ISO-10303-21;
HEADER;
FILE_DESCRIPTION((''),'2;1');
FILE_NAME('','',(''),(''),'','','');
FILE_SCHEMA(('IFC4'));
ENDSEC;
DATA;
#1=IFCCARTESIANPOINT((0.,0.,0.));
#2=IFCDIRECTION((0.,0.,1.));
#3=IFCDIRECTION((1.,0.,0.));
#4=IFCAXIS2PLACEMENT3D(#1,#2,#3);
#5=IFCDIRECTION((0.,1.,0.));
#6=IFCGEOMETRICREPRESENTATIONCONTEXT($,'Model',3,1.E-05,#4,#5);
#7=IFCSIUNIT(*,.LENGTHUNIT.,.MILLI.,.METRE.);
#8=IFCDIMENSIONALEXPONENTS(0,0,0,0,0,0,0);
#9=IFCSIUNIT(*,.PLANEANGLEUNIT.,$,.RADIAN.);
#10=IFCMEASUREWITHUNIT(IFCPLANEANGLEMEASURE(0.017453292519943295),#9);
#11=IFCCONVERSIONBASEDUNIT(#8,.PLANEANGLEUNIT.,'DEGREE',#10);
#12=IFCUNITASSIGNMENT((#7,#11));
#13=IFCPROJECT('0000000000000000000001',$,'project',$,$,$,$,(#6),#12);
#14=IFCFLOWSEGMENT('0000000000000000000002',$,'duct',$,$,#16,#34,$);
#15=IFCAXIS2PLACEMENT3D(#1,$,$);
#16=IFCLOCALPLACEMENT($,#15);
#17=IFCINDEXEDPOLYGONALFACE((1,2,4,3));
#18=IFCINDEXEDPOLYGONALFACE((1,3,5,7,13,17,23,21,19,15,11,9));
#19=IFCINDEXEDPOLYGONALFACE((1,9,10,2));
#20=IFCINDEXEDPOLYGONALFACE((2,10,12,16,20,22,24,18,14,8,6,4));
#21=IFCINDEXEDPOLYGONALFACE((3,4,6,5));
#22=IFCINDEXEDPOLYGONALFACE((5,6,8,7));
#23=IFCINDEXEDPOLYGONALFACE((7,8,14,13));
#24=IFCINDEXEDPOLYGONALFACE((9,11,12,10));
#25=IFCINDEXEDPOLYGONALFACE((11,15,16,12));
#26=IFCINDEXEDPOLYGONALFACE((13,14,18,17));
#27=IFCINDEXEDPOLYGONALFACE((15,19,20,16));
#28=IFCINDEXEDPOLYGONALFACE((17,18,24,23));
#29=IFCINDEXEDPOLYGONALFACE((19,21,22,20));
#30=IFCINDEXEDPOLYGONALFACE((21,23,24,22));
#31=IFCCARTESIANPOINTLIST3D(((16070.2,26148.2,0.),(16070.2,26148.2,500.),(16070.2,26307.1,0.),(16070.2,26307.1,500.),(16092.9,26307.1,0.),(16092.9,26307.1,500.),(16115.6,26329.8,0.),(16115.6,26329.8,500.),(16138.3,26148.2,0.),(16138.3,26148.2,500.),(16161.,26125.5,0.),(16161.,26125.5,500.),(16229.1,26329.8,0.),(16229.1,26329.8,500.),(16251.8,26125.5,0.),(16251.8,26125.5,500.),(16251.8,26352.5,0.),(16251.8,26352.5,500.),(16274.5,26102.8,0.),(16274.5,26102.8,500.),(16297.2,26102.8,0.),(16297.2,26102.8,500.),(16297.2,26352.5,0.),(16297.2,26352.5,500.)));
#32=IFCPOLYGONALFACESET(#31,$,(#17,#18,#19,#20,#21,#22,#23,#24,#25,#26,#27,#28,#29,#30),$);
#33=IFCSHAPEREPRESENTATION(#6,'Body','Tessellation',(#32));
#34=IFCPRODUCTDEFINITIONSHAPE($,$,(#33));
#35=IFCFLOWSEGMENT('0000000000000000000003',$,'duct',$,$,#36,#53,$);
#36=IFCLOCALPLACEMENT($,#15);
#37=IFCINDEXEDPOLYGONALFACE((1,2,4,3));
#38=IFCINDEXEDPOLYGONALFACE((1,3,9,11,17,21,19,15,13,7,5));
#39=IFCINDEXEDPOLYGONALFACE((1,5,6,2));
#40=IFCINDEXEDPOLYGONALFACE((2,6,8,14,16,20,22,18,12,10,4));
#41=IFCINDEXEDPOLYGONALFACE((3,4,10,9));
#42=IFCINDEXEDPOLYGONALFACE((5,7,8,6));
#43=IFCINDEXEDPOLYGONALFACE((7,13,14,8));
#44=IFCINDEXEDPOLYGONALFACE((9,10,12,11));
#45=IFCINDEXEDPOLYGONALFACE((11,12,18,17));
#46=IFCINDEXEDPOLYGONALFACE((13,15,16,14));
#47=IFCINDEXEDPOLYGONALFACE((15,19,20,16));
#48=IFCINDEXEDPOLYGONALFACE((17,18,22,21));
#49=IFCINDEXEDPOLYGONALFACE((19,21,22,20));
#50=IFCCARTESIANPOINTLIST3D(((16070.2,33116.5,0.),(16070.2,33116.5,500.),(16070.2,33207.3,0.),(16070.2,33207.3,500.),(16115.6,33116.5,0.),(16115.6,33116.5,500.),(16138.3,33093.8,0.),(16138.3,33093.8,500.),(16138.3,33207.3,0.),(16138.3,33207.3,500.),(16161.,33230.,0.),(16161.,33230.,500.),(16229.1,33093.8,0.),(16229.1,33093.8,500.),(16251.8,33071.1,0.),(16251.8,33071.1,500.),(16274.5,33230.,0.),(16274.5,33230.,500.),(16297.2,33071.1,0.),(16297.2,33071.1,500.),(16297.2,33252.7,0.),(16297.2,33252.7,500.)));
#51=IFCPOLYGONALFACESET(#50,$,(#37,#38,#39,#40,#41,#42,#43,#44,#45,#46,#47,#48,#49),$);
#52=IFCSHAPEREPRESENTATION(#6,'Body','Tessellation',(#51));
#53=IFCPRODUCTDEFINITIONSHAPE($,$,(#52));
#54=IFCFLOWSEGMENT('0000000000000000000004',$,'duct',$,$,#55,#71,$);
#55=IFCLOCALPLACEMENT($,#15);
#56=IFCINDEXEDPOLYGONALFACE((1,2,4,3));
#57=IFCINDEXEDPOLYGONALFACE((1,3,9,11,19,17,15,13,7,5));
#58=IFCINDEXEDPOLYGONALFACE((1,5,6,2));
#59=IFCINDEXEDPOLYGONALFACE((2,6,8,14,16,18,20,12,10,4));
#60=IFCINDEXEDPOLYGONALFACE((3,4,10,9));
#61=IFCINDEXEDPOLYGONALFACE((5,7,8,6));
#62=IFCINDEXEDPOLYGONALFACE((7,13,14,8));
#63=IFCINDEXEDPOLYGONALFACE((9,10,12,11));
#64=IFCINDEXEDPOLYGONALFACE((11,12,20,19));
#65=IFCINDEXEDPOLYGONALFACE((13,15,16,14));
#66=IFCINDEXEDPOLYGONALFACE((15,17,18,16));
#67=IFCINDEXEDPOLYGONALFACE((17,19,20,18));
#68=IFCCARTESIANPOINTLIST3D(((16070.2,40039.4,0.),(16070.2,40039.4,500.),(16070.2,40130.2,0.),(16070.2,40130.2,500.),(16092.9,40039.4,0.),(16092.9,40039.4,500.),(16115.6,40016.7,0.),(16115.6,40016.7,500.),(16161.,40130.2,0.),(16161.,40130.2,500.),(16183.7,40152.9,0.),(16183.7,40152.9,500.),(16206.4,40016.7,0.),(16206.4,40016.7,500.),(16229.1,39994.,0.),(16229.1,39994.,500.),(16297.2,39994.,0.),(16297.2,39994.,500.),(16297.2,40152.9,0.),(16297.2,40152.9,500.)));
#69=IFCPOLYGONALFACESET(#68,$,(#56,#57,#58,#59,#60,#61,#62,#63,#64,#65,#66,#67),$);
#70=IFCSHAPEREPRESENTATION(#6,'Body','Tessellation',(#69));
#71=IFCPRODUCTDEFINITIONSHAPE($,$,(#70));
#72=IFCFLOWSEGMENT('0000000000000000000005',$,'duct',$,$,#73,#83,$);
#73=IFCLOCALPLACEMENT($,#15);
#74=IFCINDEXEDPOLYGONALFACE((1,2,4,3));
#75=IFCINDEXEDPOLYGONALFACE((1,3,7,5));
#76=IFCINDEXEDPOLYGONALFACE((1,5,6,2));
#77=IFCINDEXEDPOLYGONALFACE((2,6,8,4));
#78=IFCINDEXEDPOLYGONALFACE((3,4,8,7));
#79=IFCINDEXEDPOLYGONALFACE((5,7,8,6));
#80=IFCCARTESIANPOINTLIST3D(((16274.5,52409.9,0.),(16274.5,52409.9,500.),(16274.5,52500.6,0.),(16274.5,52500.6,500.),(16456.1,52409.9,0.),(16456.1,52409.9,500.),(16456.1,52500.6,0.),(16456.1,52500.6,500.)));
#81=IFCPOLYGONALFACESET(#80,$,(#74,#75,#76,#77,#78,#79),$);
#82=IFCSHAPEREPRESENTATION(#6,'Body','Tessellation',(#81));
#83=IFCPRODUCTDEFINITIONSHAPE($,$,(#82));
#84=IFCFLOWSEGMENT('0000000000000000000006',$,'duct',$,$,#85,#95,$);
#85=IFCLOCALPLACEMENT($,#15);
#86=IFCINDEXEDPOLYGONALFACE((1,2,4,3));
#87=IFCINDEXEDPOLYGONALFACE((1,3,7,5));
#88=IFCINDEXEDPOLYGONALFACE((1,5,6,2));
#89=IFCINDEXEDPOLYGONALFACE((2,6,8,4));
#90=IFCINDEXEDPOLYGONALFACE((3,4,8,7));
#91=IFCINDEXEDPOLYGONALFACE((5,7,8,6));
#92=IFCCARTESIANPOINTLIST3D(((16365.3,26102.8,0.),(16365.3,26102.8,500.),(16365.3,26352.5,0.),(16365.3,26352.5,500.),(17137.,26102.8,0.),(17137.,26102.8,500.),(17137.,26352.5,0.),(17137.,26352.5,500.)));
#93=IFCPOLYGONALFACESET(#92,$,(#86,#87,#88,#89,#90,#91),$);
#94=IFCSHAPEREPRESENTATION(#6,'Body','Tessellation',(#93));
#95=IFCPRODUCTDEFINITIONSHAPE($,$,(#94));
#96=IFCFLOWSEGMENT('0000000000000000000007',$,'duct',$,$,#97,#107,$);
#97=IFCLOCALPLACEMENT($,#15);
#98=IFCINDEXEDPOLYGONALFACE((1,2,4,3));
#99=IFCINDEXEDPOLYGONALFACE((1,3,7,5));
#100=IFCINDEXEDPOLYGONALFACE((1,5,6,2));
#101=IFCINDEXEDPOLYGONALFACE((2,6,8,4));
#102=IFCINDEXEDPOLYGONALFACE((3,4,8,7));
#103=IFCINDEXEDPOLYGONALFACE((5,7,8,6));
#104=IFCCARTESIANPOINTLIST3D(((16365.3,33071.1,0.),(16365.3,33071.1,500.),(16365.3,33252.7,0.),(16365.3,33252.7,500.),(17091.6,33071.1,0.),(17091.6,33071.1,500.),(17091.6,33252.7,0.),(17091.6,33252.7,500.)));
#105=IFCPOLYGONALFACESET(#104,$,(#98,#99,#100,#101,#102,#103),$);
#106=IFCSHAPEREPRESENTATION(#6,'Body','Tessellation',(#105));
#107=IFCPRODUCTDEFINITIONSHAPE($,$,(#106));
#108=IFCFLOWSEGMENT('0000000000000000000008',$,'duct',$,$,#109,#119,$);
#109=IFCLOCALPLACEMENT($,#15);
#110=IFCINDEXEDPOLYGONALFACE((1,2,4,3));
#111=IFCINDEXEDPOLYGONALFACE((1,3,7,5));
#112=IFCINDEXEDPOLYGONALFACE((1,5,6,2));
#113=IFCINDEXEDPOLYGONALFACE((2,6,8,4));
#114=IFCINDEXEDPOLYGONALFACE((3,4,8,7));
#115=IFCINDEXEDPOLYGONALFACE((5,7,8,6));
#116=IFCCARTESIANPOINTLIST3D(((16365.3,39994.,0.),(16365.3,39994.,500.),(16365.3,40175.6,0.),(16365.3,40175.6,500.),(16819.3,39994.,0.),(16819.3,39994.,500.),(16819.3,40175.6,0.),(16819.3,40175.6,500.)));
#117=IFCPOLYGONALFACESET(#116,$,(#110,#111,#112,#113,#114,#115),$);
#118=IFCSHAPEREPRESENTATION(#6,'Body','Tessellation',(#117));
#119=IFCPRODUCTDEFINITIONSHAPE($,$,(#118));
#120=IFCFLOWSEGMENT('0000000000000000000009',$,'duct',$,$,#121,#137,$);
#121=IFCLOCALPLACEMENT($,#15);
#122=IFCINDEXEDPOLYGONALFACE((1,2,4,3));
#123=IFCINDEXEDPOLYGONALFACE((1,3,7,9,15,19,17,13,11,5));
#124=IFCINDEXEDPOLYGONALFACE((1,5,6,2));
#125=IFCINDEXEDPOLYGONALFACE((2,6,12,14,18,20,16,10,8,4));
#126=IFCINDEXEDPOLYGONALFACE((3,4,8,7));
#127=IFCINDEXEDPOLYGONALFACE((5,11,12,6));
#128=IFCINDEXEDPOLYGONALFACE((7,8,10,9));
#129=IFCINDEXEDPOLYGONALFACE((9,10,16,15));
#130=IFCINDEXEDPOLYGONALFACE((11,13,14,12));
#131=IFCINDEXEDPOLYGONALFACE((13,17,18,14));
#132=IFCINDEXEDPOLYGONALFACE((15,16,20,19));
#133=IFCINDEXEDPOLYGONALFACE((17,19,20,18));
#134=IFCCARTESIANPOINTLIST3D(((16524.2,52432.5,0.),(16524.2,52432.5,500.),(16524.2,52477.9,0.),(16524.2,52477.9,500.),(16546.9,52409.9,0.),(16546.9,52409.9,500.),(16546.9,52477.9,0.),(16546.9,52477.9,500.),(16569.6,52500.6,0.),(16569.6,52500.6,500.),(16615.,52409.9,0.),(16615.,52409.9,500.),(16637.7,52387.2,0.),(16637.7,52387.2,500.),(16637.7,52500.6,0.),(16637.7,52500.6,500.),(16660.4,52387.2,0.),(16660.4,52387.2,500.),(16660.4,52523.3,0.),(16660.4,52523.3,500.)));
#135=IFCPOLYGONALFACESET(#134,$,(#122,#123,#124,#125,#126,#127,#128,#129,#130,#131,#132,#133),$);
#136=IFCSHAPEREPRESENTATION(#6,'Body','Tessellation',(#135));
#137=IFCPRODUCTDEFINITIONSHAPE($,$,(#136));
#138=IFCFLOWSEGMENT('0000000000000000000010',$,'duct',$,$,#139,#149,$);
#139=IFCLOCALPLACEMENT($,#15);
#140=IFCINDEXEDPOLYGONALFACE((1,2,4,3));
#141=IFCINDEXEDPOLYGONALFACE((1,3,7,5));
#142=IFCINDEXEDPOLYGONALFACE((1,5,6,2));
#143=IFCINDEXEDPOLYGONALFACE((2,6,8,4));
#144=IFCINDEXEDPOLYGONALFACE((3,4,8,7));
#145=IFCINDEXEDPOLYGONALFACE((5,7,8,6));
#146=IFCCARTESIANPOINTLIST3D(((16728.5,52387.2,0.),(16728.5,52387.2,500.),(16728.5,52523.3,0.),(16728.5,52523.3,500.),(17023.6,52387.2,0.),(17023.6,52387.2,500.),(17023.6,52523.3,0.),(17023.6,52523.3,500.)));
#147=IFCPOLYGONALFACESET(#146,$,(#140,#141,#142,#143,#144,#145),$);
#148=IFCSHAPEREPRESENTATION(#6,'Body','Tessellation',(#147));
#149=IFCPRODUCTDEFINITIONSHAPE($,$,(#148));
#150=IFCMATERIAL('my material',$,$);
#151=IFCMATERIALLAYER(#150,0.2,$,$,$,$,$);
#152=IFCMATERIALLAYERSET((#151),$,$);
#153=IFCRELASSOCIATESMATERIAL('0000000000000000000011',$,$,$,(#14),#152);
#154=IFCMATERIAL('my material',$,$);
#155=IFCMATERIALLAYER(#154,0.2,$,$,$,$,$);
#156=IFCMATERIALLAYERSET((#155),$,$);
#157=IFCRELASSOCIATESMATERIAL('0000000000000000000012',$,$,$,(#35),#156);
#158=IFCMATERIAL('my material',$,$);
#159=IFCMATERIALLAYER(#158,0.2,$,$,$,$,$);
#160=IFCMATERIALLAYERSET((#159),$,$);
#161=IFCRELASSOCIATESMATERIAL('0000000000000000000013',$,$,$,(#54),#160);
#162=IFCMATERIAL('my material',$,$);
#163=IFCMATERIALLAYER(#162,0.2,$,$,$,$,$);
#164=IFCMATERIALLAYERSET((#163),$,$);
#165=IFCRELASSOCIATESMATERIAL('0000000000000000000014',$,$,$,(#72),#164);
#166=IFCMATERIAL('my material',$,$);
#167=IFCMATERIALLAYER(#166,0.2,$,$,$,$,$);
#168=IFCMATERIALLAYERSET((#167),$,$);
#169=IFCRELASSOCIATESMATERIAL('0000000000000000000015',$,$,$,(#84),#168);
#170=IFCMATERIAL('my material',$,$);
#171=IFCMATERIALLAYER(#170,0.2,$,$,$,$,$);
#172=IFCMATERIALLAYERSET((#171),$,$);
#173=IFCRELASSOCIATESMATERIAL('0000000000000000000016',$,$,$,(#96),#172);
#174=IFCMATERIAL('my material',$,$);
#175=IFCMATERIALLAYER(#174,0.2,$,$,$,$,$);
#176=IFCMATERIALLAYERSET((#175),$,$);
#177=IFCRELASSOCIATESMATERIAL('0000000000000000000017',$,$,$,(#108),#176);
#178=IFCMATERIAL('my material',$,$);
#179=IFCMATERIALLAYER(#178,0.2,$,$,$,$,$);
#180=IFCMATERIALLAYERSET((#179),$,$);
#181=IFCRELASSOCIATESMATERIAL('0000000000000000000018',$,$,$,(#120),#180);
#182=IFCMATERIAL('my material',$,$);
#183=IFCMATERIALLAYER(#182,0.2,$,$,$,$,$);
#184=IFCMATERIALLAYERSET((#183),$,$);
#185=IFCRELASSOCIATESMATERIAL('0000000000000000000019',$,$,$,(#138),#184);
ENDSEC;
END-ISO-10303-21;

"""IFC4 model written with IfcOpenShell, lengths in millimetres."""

from ifc_helpers import new_model, entity, si_unit, converted_unit, direction, origin_with_axes, place, context, project, polyline, outline, extrude, material, layer, layer_set, layer_usage, element, save


model = new_model("IFC4")

# Units and contexts
model_context = context("Model", 3, precision=1e-05, world=origin_with_axes(), true_north=direction((0.0, 1.0, 0.0)))
ifc_project = project(units=[si_unit("LENGTHUNIT", "METRE", prefix="MILLI"), converted_unit("PLANEANGLEUNIT", "DEGREE", entity("IfcPlaneAngleMeasure", 0.017453292519943295), si_unit("PLANEANGLEUNIT", "RADIAN"), dimensions=[0, 0, 0, 0, 0, 0, 0])], contexts=[model_context])

# Flow segments
ifc_material_1 = material(Name="my material")
ifc_layer_1 = layer(ifc_material_1, 0.2)
ifc_layer_set_1 = layer_set([ifc_layer_1])
ifc_layer_usage_1 = layer_usage(ifc_layer_set_1, "AXIS2", "POSITIVE", -0.1)
flow_segment_1_placement = place(None, origin_with_axes())
element("IfcFlowSegment", 1, at=flow_segment_1_placement, material=ifc_layer_usage_1, Name="duct", context=model_context, shape_type="SweptSolid", body=[
    extrude(outline(polyline([(16070.2, 26148.2), (16138.3, 26148.2), (16161.0, 26125.5), (16251.8, 26125.5), (16274.5, 26102.8), (16297.2, 26102.8), (16297.2, 26352.5), (16251.8, 26352.5), (16229.1, 26329.8), (16115.6, 26329.8), (16092.9, 26307.1), (16070.2, 26307.1), (16070.2, 26148.2)])), origin_with_axes(), (0.0, 0.0, 1.0), 500.0),
])
ifc_material_2 = material(Name="my material")
ifc_layer_2 = layer(ifc_material_2, 0.2)
ifc_layer_set_2 = layer_set([ifc_layer_2])
ifc_layer_usage_2 = layer_usage(ifc_layer_set_2, "AXIS2", "POSITIVE", -0.1)
flow_segment_2_placement = place(None, origin_with_axes())
element("IfcFlowSegment", 2, at=flow_segment_2_placement, material=ifc_layer_usage_2, Name="duct", context=model_context, shape_type="SweptSolid", body=[
    extrude(outline(polyline([(16070.2, 33116.5), (16115.6, 33116.5), (16138.3, 33093.8), (16229.1, 33093.8), (16251.8, 33071.1), (16297.2, 33071.1), (16297.2, 33252.7), (16274.5, 33230.0), (16161.0, 33230.0), (16138.3, 33207.3), (16070.2, 33207.3), (16070.2, 33116.5)])), origin_with_axes(), (0.0, 0.0, 1.0), 500.0),
])
ifc_material_3 = material(Name="my material")
ifc_layer_3 = layer(ifc_material_3, 0.2)
ifc_layer_set_3 = layer_set([ifc_layer_3])
ifc_layer_usage_3 = layer_usage(ifc_layer_set_3, "AXIS2", "POSITIVE", -0.1)
flow_segment_3_placement = place(None, origin_with_axes())
element("IfcFlowSegment", 3, at=flow_segment_3_placement, material=ifc_layer_usage_3, Name="duct", context=model_context, shape_type="SweptSolid", body=[
    extrude(outline(polyline([(16070.2, 40039.4), (16092.9, 40039.4), (16115.6, 40016.7), (16206.4, 40016.7), (16229.1, 39994.0), (16297.2, 39994.0), (16297.2, 40152.9), (16183.7, 40152.9), (16161.0, 40130.2), (16070.2, 40130.2), (16070.2, 40039.4)])), origin_with_axes(), (0.0, 0.0, 1.0), 500.0),
])
ifc_material_4 = material(Name="my material")
ifc_layer_4 = layer(ifc_material_4, 0.2)
ifc_layer_set_4 = layer_set([ifc_layer_4])
ifc_layer_usage_4 = layer_usage(ifc_layer_set_4, "AXIS2", "POSITIVE", -0.1)
flow_segment_4_placement = place(None, origin_with_axes())
element("IfcFlowSegment", 4, at=flow_segment_4_placement, material=ifc_layer_usage_4, Name="duct", context=model_context, shape_type="SweptSolid", body=[
    extrude(outline(polyline([(16274.5, 52409.9), (16456.1, 52409.9), (16456.1, 52500.6), (16274.5, 52500.6), (16274.5, 52409.9)])), origin_with_axes(), (0.0, 0.0, 1.0), 500.0),
])
ifc_material_5 = material(Name="my material")
ifc_layer_5 = layer(ifc_material_5, 0.2)
ifc_layer_set_5 = layer_set([ifc_layer_5])
ifc_layer_usage_5 = layer_usage(ifc_layer_set_5, "AXIS2", "POSITIVE", -0.1)
flow_segment_5_placement = place(None, origin_with_axes())
element("IfcFlowSegment", 5, at=flow_segment_5_placement, material=ifc_layer_usage_5, Name="duct", context=model_context, shape_type="SweptSolid", body=[
    extrude(outline(polyline([(16365.3, 26102.8), (17137.0, 26102.8), (17137.0, 26352.5), (16365.3, 26352.5), (16365.3, 26102.8)])), origin_with_axes(), (0.0, 0.0, 1.0), 500.0),
])
ifc_material_6 = material(Name="my material")
ifc_layer_6 = layer(ifc_material_6, 0.2)
ifc_layer_set_6 = layer_set([ifc_layer_6])
ifc_layer_usage_6 = layer_usage(ifc_layer_set_6, "AXIS2", "POSITIVE", -0.1)
flow_segment_6_placement = place(None, origin_with_axes())
element("IfcFlowSegment", 6, at=flow_segment_6_placement, material=ifc_layer_usage_6, Name="duct", context=model_context, shape_type="SweptSolid", body=[
    extrude(outline(polyline([(16365.3, 33071.1), (17091.6, 33071.1), (17091.6, 33252.7), (16365.3, 33252.7), (16365.3, 33071.1)])), origin_with_axes(), (0.0, 0.0, 1.0), 500.0),
])
ifc_material_7 = material(Name="my material")
ifc_layer_7 = layer(ifc_material_7, 0.2)
ifc_layer_set_7 = layer_set([ifc_layer_7])
ifc_layer_usage_7 = layer_usage(ifc_layer_set_7, "AXIS2", "POSITIVE", -0.1)
flow_segment_7_placement = place(None, origin_with_axes())
element("IfcFlowSegment", 7, at=flow_segment_7_placement, material=ifc_layer_usage_7, Name="duct", context=model_context, shape_type="SweptSolid", body=[
    extrude(outline(polyline([(16365.3, 39994.0), (16819.3, 39994.0), (16819.3, 40175.6), (16365.3, 40175.6), (16365.3, 39994.0)])), origin_with_axes(), (0.0, 0.0, 1.0), 500.0),
])
ifc_material_8 = material(Name="my material")
ifc_layer_8 = layer(ifc_material_8, 0.2)
ifc_layer_set_8 = layer_set([ifc_layer_8])
ifc_layer_usage_8 = layer_usage(ifc_layer_set_8, "AXIS2", "POSITIVE", -0.1)
flow_segment_8_placement = place(None, origin_with_axes())
element("IfcFlowSegment", 8, at=flow_segment_8_placement, material=ifc_layer_usage_8, Name="duct", context=model_context, shape_type="SweptSolid", body=[
    extrude(outline(polyline([(16524.2, 52432.5), (16546.9, 52409.9), (16615.0, 52409.9), (16637.7, 52387.2), (16660.4, 52387.2), (16660.4, 52523.3), (16637.7, 52500.6), (16569.6, 52500.6), (16546.9, 52477.9), (16524.2, 52477.9), (16524.2, 52432.5)])), origin_with_axes(), (0.0, 0.0, 1.0), 500.0),
])
ifc_material_9 = material(Name="my material")
ifc_layer_9 = layer(ifc_material_9, 0.2)
ifc_layer_set_9 = layer_set([ifc_layer_9])
ifc_layer_usage_9 = layer_usage(ifc_layer_set_9, "AXIS2", "POSITIVE", -0.1)
flow_segment_9_placement = place(None, origin_with_axes())
element("IfcFlowSegment", 9, at=flow_segment_9_placement, material=ifc_layer_usage_9, Name="duct", context=model_context, shape_type="SweptSolid", body=[
    extrude(outline(polyline([(16728.5, 52387.2), (17023.6, 52387.2), (17023.6, 52523.3), (16728.5, 52523.3), (16728.5, 52387.2)])), origin_with_axes(), (0.0, 0.0, 1.0), 500.0),
])

save(model, "model.ifc")
